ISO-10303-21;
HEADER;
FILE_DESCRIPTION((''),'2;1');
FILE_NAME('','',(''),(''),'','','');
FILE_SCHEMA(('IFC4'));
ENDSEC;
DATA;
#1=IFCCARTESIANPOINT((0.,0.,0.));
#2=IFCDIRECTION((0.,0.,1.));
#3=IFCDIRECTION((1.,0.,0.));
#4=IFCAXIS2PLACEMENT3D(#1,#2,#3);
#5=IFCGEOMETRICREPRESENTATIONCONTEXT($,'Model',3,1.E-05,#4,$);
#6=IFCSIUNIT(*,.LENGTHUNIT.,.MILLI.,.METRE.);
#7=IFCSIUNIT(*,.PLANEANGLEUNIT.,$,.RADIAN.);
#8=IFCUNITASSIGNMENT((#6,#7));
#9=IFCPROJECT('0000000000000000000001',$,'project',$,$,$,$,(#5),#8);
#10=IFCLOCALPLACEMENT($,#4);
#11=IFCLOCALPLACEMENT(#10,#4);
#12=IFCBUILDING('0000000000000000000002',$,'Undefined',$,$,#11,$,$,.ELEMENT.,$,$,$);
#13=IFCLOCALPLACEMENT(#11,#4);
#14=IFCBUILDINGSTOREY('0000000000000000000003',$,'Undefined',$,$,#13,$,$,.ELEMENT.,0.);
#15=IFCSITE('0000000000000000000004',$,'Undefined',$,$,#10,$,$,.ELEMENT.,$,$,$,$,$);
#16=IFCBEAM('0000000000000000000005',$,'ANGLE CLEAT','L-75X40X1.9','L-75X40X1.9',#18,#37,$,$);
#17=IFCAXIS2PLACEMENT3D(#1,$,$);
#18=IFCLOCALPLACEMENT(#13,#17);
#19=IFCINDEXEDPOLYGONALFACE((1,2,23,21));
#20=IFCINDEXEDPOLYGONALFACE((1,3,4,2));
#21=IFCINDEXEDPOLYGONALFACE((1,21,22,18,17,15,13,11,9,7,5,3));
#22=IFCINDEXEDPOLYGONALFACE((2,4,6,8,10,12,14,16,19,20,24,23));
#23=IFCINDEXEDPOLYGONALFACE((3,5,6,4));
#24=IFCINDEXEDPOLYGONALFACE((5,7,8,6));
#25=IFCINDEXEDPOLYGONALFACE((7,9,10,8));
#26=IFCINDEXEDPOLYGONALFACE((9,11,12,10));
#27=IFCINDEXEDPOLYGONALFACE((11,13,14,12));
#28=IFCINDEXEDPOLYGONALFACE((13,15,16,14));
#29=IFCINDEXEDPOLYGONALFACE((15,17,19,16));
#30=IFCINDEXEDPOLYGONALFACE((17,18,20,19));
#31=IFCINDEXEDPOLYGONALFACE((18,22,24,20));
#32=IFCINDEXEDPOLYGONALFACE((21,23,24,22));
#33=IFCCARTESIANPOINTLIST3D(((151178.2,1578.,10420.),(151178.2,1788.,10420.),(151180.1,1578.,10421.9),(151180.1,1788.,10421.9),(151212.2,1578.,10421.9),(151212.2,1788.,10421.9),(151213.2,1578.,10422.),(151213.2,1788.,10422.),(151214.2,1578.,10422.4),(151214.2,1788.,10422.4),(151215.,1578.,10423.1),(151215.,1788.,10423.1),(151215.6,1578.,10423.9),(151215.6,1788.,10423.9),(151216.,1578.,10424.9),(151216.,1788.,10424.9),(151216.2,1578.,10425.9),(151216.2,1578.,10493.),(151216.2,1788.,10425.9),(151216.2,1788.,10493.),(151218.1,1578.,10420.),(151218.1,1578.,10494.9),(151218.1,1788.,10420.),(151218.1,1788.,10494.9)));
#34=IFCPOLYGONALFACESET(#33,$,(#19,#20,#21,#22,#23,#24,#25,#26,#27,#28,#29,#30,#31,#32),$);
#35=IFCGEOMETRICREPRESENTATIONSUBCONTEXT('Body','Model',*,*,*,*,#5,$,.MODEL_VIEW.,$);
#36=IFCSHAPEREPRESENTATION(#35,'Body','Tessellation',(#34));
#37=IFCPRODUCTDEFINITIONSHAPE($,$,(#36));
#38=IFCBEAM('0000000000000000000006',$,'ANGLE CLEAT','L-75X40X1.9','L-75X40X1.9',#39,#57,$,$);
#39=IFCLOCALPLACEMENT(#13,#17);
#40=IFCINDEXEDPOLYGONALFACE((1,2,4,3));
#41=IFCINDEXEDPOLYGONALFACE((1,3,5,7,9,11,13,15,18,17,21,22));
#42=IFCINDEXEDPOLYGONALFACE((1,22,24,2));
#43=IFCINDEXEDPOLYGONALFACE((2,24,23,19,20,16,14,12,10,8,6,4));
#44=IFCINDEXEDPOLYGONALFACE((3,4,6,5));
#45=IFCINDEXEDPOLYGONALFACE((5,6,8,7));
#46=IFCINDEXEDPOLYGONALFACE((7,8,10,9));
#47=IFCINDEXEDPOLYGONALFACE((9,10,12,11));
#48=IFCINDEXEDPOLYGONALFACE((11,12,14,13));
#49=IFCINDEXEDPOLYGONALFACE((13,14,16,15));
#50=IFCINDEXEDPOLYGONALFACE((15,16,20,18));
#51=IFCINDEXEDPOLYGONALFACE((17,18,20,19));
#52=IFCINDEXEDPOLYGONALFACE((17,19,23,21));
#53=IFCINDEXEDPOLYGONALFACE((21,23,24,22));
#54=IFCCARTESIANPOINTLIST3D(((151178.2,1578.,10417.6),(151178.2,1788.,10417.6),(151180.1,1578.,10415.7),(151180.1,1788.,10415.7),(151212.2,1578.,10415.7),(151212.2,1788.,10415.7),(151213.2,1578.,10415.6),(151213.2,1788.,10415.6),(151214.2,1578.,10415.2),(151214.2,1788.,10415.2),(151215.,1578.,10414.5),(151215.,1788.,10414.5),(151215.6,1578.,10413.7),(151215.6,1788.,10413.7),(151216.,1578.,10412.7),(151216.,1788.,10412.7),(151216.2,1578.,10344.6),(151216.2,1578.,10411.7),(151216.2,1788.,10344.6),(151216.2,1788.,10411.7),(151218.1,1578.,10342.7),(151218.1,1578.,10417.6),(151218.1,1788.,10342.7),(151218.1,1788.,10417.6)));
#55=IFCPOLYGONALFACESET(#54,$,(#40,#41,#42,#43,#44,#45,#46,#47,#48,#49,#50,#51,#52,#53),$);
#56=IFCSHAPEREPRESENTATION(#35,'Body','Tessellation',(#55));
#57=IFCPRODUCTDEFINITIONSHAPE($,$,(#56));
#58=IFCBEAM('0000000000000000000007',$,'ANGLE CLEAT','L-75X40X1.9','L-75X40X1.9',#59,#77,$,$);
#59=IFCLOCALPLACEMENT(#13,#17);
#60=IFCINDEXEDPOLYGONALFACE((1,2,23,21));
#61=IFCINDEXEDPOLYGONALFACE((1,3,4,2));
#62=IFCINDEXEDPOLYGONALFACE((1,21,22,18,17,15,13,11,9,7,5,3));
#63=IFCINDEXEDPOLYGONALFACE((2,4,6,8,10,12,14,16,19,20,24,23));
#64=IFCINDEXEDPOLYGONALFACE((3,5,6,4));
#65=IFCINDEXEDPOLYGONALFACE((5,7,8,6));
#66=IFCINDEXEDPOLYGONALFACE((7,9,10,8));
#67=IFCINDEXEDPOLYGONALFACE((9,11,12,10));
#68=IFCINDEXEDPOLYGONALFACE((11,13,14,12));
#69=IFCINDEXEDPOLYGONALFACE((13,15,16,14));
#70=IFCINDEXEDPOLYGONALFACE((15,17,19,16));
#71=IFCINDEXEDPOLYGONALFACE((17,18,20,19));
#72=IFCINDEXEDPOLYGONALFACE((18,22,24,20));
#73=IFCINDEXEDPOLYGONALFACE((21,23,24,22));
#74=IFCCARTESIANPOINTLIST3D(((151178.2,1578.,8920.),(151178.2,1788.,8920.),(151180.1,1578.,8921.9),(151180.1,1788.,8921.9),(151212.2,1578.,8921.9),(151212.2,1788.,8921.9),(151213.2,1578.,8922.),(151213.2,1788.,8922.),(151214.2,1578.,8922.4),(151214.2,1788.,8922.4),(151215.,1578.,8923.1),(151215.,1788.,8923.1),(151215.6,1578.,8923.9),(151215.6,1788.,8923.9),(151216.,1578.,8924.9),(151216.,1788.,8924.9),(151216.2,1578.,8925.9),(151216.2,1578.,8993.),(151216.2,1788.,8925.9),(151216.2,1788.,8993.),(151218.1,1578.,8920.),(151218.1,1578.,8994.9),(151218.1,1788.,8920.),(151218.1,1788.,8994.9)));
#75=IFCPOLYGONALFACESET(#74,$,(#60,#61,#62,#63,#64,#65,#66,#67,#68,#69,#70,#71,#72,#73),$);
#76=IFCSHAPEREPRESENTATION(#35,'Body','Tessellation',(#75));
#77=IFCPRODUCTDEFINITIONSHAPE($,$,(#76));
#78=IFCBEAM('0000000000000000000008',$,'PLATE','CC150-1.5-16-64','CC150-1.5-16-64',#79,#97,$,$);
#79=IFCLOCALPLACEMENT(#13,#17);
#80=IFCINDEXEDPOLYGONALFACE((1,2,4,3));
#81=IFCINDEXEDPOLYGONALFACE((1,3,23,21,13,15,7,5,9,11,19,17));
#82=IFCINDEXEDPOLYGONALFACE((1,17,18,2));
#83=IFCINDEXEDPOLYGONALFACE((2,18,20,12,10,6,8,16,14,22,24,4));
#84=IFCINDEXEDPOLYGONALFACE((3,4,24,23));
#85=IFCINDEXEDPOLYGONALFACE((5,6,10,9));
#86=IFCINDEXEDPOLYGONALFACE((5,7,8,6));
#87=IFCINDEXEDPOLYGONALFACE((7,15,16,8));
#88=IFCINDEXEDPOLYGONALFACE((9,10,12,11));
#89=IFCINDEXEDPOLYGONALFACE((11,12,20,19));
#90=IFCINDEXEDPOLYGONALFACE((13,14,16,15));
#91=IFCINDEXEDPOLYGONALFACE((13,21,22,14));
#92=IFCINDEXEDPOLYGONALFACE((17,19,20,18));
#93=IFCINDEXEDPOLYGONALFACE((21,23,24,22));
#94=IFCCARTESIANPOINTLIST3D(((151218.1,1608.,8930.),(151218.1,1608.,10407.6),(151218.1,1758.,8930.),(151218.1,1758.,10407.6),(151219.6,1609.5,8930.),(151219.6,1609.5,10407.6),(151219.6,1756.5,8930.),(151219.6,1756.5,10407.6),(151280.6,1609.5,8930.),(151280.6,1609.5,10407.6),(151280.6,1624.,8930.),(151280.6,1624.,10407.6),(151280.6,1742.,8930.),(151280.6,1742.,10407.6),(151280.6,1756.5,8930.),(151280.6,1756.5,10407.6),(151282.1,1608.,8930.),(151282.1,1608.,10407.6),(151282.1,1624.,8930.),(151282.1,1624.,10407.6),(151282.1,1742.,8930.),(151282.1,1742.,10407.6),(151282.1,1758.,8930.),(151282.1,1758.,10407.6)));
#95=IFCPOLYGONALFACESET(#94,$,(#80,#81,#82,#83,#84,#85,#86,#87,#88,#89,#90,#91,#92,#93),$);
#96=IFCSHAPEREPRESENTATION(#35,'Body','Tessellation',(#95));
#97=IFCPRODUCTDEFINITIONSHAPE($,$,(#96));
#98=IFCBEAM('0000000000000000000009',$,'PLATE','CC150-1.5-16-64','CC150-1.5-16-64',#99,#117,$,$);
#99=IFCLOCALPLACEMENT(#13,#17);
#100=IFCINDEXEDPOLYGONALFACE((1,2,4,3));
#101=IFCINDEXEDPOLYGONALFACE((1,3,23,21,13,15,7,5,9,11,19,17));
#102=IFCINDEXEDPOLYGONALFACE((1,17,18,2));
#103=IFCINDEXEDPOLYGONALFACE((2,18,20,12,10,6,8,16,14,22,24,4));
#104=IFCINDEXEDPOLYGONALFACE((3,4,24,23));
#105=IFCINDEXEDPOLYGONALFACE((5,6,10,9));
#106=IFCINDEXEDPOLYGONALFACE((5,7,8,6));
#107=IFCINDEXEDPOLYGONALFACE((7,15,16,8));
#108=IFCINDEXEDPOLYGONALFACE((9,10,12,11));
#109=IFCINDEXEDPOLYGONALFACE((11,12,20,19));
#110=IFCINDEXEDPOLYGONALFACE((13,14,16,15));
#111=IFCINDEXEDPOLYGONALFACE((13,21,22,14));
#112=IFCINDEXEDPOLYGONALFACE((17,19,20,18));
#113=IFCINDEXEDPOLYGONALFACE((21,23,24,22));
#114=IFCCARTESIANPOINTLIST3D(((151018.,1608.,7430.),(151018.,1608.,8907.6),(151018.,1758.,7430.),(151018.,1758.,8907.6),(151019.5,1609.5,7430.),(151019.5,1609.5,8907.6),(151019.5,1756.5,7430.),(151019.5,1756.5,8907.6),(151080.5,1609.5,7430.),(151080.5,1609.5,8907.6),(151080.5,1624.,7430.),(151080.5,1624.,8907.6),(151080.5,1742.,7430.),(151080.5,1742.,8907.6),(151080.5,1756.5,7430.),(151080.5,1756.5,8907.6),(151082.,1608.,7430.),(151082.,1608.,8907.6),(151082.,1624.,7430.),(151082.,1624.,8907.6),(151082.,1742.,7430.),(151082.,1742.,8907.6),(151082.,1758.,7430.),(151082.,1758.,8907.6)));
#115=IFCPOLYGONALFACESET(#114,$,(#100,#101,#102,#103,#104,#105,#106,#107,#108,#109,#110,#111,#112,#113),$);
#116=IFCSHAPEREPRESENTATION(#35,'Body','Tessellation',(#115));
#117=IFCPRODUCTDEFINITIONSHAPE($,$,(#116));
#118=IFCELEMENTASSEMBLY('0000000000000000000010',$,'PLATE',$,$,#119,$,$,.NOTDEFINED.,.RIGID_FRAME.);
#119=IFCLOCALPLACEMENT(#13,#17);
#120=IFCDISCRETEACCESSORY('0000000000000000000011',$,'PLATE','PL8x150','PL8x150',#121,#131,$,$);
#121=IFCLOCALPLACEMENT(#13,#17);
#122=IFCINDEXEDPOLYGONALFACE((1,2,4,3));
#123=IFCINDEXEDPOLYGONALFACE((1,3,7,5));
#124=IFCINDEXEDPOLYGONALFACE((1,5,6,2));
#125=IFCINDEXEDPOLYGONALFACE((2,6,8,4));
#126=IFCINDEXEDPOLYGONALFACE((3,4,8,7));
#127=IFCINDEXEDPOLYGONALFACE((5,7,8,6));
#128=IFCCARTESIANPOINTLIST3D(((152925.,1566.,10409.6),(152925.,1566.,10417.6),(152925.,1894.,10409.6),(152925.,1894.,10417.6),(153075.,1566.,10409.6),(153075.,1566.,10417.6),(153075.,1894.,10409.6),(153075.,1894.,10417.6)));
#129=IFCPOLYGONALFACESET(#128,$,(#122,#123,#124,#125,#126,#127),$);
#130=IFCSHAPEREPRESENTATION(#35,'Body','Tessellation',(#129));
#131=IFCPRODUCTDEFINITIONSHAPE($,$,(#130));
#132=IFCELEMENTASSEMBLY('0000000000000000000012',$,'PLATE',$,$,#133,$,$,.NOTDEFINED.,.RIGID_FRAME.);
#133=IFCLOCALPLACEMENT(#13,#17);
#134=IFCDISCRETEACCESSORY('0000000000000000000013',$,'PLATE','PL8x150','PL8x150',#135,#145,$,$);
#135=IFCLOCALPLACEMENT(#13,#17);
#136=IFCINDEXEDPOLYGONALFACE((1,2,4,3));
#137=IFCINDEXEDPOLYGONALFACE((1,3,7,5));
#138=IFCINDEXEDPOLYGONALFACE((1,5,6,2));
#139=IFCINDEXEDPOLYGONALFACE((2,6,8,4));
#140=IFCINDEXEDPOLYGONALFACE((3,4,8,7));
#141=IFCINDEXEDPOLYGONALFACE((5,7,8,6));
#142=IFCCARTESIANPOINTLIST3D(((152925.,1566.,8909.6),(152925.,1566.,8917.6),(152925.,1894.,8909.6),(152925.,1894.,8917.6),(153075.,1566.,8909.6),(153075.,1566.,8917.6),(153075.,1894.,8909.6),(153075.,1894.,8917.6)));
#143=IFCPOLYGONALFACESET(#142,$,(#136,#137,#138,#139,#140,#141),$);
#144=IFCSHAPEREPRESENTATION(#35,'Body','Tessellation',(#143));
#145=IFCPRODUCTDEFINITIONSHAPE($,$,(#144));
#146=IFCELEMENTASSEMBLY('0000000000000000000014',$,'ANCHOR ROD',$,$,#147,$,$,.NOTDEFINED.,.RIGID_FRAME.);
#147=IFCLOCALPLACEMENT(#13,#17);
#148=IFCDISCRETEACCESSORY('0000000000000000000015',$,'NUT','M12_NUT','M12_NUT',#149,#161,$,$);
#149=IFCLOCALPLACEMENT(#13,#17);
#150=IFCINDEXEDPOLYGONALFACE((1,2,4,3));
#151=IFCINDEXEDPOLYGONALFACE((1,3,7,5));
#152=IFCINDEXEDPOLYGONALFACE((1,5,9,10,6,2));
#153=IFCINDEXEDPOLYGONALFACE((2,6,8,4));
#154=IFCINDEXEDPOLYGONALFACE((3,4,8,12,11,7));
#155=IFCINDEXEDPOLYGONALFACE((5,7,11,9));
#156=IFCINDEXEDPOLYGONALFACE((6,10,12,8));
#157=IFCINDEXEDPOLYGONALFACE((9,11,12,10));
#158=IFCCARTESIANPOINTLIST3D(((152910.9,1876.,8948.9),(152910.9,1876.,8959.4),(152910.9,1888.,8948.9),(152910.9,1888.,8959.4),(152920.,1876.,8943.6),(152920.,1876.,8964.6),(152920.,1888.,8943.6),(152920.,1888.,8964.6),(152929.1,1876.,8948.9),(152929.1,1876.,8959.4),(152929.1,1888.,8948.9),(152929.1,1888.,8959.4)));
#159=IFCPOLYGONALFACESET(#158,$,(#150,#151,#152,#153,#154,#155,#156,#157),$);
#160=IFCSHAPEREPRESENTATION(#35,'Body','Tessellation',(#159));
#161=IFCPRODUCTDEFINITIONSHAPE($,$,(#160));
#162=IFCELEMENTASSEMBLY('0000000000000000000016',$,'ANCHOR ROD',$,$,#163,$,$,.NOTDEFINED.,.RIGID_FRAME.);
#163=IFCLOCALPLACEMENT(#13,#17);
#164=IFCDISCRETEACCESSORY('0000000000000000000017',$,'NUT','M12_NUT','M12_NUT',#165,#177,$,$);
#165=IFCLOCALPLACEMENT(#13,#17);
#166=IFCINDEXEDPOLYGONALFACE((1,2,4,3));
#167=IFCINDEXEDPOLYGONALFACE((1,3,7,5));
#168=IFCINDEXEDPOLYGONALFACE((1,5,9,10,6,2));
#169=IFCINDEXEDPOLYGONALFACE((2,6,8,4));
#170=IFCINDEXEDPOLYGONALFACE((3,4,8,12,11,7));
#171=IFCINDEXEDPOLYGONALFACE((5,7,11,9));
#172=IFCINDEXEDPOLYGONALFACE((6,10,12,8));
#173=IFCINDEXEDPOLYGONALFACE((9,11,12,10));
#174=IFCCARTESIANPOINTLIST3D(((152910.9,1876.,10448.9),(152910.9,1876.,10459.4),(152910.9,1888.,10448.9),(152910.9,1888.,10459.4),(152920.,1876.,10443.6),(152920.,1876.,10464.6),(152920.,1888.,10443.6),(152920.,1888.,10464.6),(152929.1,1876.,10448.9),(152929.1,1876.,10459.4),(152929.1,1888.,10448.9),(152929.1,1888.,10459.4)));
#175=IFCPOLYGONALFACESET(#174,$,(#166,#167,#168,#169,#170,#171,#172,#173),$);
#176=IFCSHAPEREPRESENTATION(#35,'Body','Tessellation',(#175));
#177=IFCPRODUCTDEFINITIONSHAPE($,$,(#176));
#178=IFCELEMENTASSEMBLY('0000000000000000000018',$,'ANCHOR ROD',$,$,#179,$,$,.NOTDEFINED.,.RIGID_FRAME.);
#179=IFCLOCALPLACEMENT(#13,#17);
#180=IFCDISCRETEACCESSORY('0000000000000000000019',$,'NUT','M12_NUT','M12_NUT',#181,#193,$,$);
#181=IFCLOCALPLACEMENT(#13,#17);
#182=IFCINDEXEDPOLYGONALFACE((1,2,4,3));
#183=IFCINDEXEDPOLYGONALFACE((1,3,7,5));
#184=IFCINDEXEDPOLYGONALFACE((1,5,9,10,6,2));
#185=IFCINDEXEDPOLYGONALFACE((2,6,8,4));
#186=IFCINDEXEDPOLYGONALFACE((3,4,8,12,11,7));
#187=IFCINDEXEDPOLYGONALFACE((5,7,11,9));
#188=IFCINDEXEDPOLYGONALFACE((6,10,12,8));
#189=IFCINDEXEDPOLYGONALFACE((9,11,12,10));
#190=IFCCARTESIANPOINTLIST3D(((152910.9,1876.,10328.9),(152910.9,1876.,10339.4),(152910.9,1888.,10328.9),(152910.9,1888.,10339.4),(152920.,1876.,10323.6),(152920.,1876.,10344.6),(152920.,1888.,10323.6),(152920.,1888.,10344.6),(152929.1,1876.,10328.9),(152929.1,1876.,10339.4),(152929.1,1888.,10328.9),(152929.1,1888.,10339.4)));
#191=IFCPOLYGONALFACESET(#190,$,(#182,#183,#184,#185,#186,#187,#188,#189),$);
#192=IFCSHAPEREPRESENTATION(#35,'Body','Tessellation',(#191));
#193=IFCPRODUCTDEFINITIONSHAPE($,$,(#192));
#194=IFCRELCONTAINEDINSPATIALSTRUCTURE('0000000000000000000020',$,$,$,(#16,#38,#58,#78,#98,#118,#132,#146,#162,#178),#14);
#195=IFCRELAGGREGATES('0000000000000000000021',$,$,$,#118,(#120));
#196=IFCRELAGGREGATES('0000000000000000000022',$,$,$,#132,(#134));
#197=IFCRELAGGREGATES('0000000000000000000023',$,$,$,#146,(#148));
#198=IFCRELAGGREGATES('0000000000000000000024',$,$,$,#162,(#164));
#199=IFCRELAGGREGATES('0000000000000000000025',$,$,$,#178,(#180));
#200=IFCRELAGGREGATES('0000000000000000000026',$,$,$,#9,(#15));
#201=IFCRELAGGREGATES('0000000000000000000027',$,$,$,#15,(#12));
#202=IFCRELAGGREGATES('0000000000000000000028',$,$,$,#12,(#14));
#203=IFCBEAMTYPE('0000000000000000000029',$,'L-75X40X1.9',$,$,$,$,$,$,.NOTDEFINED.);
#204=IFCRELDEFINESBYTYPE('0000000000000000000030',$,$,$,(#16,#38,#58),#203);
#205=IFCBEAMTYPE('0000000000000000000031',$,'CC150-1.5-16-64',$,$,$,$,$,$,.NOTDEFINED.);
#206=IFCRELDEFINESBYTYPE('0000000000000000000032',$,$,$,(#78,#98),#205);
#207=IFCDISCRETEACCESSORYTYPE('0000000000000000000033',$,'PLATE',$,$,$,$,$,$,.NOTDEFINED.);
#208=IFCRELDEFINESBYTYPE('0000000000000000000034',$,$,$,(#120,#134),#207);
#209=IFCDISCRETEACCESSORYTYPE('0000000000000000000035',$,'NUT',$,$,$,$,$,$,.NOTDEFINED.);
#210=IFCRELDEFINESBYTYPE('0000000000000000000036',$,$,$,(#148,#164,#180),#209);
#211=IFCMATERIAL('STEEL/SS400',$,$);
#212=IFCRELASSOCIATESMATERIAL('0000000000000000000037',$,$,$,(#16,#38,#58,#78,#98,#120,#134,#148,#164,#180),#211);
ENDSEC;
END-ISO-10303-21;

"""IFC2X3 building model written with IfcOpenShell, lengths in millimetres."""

from ifc_helpers import new_model, si_unit, frame, origin_with_axes, origin_2d_with_axis, place, context, subcontext, project, spatial, polyline, l_section, c_section, outline, extrude, material, type_object, element, aggregate, save


model = new_model("IFC2X3")

# Units and contexts
model_context = context("Model", 3, precision=1e-05, world=origin_with_axes())
body_context = subcontext(model_context, "Body", "Model", "MODEL_VIEW")
ifc_project = project(units=[si_unit("LENGTHUNIT", "METRE", prefix="MILLI"), si_unit("PLANEANGLEUNIT", "RADIAN")], contexts=[model_context])

# Site, building, storey
site_placement = place(None, origin_with_axes())
site = spatial("IfcSite", under=ifc_project, at=site_placement, Name="Undefined", CompositionType="ELEMENT")
building_placement = place(site_placement, origin_with_axes())
building = spatial("IfcBuilding", under=site, at=building_placement, Name="Undefined", CompositionType="ELEMENT")
storey_placement = place(building_placement, origin_with_axes())
storey = spatial("IfcBuildingStorey", under=building, at=storey_placement, Name="Undefined", CompositionType="ELEMENT", Elevation=0.0)

# Beams
ifc_material_1 = material(Name="STEEL/SS400")
beam_type_1 = type_object("IfcBeamType", Name="L-75X40X1.9", PredefinedType="NOTDEFINED")
for number, where, z_axis, x_axis, name in (
    (1, (151198.1, 1788.0, 10457.5), (0.0, 0.0, 1.0), (0.0, -1.0, 0.0), "ANGLE CLEAT"),
    (2, (151198.1, 1578.0, 10380.1), (0.0, 0.0, -1.0), (0.0, 1.0, 0.0), "ANGLE CLEAT"),
    (3, (151198.1, 1788.0, 8957.5), (0.0, 0.0, 1.0), (0.0, -1.0, 0.0), "ANGLE CLEAT"),
):
    element("IfcBeam", number, at=place(storey_placement, frame(where, z_axis=z_axis, x_axis=x_axis)), inside=storey, type_object=beam_type_1, material=ifc_material_1, Name=name, Description="L-75X40X1.9", ObjectType="L-75X40X1.9", context=body_context, shape_type="SweptSolid", body=[
        extrude(l_section(Depth=75.0, Width=40.0, Thickness=1.9, FilletRadius=4.0, EdgeRadius=2.0, at=origin_2d_with_axis()), frame((210.0, 0.0, 0.0), z_axis=(-1.0, 0.0, 0.0), x_axis=(0.0, -1.0, 0.0)), (0.0, 0.0, 1.0), 210.0),
    ])
beam_type_2 = type_object("IfcBeamType", Name="CC150-1.5-16-64", PredefinedType="NOTDEFINED")
for number, where, z_axis, x_axis, name in (
    (4, (151250.1, 1683.0, 10407.6), (0.0, 1.0, 0.0), (0.0, 0.0, -1.0), "PLATE"),
    (5, (151050.0, 1683.0, 8907.6), (0.0, 1.0, 0.0), (0.0, 0.0, -1.0), "PLATE"),
):
    element("IfcBeam", number, at=place(storey_placement, frame(where, z_axis=z_axis, x_axis=x_axis)), inside=storey, type_object=beam_type_2, material=ifc_material_1, Name=name, Description="CC150-1.5-16-64", ObjectType="CC150-1.5-16-64", context=body_context, shape_type="SweptSolid", body=[
        extrude(c_section(Depth=150.0, Width=64.0, WallThickness=1.5, Girth=16.0, at=origin_2d_with_axis()), frame((1477.6, 0.0, 0.0), z_axis=(-1.0, 0.0, 0.0), x_axis=(0.0, -1.0, 0.0)), (0.0, 0.0, 1.0), 1477.6),
    ])

# Element assemblies, discrete accessories
assembly_1_placement = place(storey_placement, origin_with_axes())
assembly_1 = element("IfcElementAssembly", 6, at=assembly_1_placement, inside=storey, Name="PLATE", AssemblyPlace="NOTDEFINED", PredefinedType="RIGID_FRAME")
discrete_accessory_type_1 = type_object("IfcDiscreteAccessoryType", Name="PLATE")
discrete_accessory_1_placement = place(assembly_1_placement, frame((152925.0, 1566.0, 10413.6), z_axis=(0.0, 0.0, -1.0), x_axis=(0.0, 1.0, 0.0)))
discrete_accessory_1 = element("IfcDiscreteAccessory", 7, at=discrete_accessory_1_placement, type_object=discrete_accessory_type_1, material=ifc_material_1, Name="PLATE", Description="PL8x150", ObjectType="PL8x150", context=body_context, shape_type="SweptSolid", body=[
    extrude(outline(polyline([(0.0, 0.0), (328.0, 0.0), (328.0, 150.0), (0.0, 150.0), (0.0, 0.0)])), frame((0.0, 0.0, -4.0), z_axis=(0.0, 0.0, 1.0), x_axis=(1.0, 0.0, 0.0)), (0.0, 0.0, 1.0), 8.0),
])
aggregate(assembly_1, [discrete_accessory_1])
assembly_2_placement = place(storey_placement, origin_with_axes())
assembly_2 = element("IfcElementAssembly", 8, at=assembly_2_placement, inside=storey, Name="PLATE", AssemblyPlace="NOTDEFINED", PredefinedType="RIGID_FRAME")
discrete_accessory_2_placement = place(assembly_2_placement, frame((152925.0, 1566.0, 8913.6), z_axis=(0.0, 0.0, -1.0), x_axis=(0.0, 1.0, 0.0)))
discrete_accessory_2 = element("IfcDiscreteAccessory", 9, at=discrete_accessory_2_placement, type_object=discrete_accessory_type_1, material=ifc_material_1, Name="PLATE", Description="PL8x150", ObjectType="PL8x150", context=body_context, shape_type="SweptSolid", body=[
    extrude(outline(polyline([(0.0, 0.0), (328.0, 0.0), (328.0, 150.0), (0.0, 150.0), (0.0, 0.0)])), frame((0.0, 0.0, -4.0), z_axis=(0.0, 0.0, 1.0), x_axis=(1.0, 0.0, 0.0)), (0.0, 0.0, 1.0), 8.0),
])
aggregate(assembly_2, [discrete_accessory_2])
assembly_3_placement = place(storey_placement, origin_with_axes())
assembly_3 = element("IfcElementAssembly", 10, at=assembly_3_placement, inside=storey, Name="ANCHOR ROD", AssemblyPlace="NOTDEFINED", PredefinedType="RIGID_FRAME")
discrete_accessory_type_2 = type_object("IfcDiscreteAccessoryType", Name="NUT")
discrete_accessory_3_placement = place(assembly_3_placement, frame((152920.0, 1876.0, 8954.1), z_axis=(1.0, 0.0, 0.0), x_axis=(0.0, 1.0, 0.0)))
discrete_accessory_3 = element("IfcDiscreteAccessory", 11, at=discrete_accessory_3_placement, type_object=discrete_accessory_type_2, material=ifc_material_1, Name="NUT", Description="M12_NUT", ObjectType="M12_NUT", context=body_context, shape_type="SweptSolid", body=[
    extrude(outline(polyline([(-5.2, -9.1), (-10.5, 0.0), (-5.2, 9.1), (5.3, 9.1), (10.5, 0.0), (5.3, -9.1), (-5.2, -9.1)])), frame((12.0, 0.0, 0.0), z_axis=(-1.0, 0.0, 0.0), x_axis=(0.0, -1.0, 0.0)), (0.0, 0.0, 1.0), 12.0),
])
aggregate(assembly_3, [discrete_accessory_3])
assembly_4_placement = place(storey_placement, origin_with_axes())
assembly_4 = element("IfcElementAssembly", 12, at=assembly_4_placement, inside=storey, Name="ANCHOR ROD", AssemblyPlace="NOTDEFINED", PredefinedType="RIGID_FRAME")
discrete_accessory_4_placement = place(assembly_4_placement, frame((152920.0, 1876.0, 10454.1), z_axis=(1.0, 0.0, 0.0), x_axis=(0.0, 1.0, 0.0)))
discrete_accessory_4 = element("IfcDiscreteAccessory", 13, at=discrete_accessory_4_placement, type_object=discrete_accessory_type_2, material=ifc_material_1, Name="NUT", Description="M12_NUT", ObjectType="M12_NUT", context=body_context, shape_type="SweptSolid", body=[
    extrude(outline(polyline([(-5.2, -9.1), (-10.5, 0.0), (-5.2, 9.1), (5.3, 9.1), (10.5, 0.0), (5.3, -9.1), (-5.2, -9.1)])), frame((12.0, 0.0, 0.0), z_axis=(-1.0, 0.0, 0.0), x_axis=(0.0, -1.0, 0.0)), (0.0, 0.0, 1.0), 12.0),
])
aggregate(assembly_4, [discrete_accessory_4])
assembly_5_placement = place(storey_placement, origin_with_axes())
assembly_5 = element("IfcElementAssembly", 14, at=assembly_5_placement, inside=storey, Name="ANCHOR ROD", AssemblyPlace="NOTDEFINED", PredefinedType="RIGID_FRAME")
discrete_accessory_5_placement = place(assembly_5_placement, frame((152920.0, 1876.0, 10334.1), z_axis=(-1.0, 0.0, 0.0), x_axis=(0.0, 1.0, 0.0)))
discrete_accessory_5 = element("IfcDiscreteAccessory", 15, at=discrete_accessory_5_placement, type_object=discrete_accessory_type_2, material=ifc_material_1, Name="NUT", Description="M12_NUT", ObjectType="M12_NUT", context=body_context, shape_type="SweptSolid", body=[
    extrude(outline(polyline([(-5.2, -9.1), (-10.5, 0.0), (-5.2, 9.1), (5.3, 9.1), (10.5, 0.0), (5.3, -9.1), (-5.2, -9.1)])), frame((12.0, 0.0, 0.0), z_axis=(-1.0, 0.0, 0.0), x_axis=(0.0, -1.0, 0.0)), (0.0, 0.0, 1.0), 12.0),
])
aggregate(assembly_5, [discrete_accessory_5])

save(model, "model.ifc")
